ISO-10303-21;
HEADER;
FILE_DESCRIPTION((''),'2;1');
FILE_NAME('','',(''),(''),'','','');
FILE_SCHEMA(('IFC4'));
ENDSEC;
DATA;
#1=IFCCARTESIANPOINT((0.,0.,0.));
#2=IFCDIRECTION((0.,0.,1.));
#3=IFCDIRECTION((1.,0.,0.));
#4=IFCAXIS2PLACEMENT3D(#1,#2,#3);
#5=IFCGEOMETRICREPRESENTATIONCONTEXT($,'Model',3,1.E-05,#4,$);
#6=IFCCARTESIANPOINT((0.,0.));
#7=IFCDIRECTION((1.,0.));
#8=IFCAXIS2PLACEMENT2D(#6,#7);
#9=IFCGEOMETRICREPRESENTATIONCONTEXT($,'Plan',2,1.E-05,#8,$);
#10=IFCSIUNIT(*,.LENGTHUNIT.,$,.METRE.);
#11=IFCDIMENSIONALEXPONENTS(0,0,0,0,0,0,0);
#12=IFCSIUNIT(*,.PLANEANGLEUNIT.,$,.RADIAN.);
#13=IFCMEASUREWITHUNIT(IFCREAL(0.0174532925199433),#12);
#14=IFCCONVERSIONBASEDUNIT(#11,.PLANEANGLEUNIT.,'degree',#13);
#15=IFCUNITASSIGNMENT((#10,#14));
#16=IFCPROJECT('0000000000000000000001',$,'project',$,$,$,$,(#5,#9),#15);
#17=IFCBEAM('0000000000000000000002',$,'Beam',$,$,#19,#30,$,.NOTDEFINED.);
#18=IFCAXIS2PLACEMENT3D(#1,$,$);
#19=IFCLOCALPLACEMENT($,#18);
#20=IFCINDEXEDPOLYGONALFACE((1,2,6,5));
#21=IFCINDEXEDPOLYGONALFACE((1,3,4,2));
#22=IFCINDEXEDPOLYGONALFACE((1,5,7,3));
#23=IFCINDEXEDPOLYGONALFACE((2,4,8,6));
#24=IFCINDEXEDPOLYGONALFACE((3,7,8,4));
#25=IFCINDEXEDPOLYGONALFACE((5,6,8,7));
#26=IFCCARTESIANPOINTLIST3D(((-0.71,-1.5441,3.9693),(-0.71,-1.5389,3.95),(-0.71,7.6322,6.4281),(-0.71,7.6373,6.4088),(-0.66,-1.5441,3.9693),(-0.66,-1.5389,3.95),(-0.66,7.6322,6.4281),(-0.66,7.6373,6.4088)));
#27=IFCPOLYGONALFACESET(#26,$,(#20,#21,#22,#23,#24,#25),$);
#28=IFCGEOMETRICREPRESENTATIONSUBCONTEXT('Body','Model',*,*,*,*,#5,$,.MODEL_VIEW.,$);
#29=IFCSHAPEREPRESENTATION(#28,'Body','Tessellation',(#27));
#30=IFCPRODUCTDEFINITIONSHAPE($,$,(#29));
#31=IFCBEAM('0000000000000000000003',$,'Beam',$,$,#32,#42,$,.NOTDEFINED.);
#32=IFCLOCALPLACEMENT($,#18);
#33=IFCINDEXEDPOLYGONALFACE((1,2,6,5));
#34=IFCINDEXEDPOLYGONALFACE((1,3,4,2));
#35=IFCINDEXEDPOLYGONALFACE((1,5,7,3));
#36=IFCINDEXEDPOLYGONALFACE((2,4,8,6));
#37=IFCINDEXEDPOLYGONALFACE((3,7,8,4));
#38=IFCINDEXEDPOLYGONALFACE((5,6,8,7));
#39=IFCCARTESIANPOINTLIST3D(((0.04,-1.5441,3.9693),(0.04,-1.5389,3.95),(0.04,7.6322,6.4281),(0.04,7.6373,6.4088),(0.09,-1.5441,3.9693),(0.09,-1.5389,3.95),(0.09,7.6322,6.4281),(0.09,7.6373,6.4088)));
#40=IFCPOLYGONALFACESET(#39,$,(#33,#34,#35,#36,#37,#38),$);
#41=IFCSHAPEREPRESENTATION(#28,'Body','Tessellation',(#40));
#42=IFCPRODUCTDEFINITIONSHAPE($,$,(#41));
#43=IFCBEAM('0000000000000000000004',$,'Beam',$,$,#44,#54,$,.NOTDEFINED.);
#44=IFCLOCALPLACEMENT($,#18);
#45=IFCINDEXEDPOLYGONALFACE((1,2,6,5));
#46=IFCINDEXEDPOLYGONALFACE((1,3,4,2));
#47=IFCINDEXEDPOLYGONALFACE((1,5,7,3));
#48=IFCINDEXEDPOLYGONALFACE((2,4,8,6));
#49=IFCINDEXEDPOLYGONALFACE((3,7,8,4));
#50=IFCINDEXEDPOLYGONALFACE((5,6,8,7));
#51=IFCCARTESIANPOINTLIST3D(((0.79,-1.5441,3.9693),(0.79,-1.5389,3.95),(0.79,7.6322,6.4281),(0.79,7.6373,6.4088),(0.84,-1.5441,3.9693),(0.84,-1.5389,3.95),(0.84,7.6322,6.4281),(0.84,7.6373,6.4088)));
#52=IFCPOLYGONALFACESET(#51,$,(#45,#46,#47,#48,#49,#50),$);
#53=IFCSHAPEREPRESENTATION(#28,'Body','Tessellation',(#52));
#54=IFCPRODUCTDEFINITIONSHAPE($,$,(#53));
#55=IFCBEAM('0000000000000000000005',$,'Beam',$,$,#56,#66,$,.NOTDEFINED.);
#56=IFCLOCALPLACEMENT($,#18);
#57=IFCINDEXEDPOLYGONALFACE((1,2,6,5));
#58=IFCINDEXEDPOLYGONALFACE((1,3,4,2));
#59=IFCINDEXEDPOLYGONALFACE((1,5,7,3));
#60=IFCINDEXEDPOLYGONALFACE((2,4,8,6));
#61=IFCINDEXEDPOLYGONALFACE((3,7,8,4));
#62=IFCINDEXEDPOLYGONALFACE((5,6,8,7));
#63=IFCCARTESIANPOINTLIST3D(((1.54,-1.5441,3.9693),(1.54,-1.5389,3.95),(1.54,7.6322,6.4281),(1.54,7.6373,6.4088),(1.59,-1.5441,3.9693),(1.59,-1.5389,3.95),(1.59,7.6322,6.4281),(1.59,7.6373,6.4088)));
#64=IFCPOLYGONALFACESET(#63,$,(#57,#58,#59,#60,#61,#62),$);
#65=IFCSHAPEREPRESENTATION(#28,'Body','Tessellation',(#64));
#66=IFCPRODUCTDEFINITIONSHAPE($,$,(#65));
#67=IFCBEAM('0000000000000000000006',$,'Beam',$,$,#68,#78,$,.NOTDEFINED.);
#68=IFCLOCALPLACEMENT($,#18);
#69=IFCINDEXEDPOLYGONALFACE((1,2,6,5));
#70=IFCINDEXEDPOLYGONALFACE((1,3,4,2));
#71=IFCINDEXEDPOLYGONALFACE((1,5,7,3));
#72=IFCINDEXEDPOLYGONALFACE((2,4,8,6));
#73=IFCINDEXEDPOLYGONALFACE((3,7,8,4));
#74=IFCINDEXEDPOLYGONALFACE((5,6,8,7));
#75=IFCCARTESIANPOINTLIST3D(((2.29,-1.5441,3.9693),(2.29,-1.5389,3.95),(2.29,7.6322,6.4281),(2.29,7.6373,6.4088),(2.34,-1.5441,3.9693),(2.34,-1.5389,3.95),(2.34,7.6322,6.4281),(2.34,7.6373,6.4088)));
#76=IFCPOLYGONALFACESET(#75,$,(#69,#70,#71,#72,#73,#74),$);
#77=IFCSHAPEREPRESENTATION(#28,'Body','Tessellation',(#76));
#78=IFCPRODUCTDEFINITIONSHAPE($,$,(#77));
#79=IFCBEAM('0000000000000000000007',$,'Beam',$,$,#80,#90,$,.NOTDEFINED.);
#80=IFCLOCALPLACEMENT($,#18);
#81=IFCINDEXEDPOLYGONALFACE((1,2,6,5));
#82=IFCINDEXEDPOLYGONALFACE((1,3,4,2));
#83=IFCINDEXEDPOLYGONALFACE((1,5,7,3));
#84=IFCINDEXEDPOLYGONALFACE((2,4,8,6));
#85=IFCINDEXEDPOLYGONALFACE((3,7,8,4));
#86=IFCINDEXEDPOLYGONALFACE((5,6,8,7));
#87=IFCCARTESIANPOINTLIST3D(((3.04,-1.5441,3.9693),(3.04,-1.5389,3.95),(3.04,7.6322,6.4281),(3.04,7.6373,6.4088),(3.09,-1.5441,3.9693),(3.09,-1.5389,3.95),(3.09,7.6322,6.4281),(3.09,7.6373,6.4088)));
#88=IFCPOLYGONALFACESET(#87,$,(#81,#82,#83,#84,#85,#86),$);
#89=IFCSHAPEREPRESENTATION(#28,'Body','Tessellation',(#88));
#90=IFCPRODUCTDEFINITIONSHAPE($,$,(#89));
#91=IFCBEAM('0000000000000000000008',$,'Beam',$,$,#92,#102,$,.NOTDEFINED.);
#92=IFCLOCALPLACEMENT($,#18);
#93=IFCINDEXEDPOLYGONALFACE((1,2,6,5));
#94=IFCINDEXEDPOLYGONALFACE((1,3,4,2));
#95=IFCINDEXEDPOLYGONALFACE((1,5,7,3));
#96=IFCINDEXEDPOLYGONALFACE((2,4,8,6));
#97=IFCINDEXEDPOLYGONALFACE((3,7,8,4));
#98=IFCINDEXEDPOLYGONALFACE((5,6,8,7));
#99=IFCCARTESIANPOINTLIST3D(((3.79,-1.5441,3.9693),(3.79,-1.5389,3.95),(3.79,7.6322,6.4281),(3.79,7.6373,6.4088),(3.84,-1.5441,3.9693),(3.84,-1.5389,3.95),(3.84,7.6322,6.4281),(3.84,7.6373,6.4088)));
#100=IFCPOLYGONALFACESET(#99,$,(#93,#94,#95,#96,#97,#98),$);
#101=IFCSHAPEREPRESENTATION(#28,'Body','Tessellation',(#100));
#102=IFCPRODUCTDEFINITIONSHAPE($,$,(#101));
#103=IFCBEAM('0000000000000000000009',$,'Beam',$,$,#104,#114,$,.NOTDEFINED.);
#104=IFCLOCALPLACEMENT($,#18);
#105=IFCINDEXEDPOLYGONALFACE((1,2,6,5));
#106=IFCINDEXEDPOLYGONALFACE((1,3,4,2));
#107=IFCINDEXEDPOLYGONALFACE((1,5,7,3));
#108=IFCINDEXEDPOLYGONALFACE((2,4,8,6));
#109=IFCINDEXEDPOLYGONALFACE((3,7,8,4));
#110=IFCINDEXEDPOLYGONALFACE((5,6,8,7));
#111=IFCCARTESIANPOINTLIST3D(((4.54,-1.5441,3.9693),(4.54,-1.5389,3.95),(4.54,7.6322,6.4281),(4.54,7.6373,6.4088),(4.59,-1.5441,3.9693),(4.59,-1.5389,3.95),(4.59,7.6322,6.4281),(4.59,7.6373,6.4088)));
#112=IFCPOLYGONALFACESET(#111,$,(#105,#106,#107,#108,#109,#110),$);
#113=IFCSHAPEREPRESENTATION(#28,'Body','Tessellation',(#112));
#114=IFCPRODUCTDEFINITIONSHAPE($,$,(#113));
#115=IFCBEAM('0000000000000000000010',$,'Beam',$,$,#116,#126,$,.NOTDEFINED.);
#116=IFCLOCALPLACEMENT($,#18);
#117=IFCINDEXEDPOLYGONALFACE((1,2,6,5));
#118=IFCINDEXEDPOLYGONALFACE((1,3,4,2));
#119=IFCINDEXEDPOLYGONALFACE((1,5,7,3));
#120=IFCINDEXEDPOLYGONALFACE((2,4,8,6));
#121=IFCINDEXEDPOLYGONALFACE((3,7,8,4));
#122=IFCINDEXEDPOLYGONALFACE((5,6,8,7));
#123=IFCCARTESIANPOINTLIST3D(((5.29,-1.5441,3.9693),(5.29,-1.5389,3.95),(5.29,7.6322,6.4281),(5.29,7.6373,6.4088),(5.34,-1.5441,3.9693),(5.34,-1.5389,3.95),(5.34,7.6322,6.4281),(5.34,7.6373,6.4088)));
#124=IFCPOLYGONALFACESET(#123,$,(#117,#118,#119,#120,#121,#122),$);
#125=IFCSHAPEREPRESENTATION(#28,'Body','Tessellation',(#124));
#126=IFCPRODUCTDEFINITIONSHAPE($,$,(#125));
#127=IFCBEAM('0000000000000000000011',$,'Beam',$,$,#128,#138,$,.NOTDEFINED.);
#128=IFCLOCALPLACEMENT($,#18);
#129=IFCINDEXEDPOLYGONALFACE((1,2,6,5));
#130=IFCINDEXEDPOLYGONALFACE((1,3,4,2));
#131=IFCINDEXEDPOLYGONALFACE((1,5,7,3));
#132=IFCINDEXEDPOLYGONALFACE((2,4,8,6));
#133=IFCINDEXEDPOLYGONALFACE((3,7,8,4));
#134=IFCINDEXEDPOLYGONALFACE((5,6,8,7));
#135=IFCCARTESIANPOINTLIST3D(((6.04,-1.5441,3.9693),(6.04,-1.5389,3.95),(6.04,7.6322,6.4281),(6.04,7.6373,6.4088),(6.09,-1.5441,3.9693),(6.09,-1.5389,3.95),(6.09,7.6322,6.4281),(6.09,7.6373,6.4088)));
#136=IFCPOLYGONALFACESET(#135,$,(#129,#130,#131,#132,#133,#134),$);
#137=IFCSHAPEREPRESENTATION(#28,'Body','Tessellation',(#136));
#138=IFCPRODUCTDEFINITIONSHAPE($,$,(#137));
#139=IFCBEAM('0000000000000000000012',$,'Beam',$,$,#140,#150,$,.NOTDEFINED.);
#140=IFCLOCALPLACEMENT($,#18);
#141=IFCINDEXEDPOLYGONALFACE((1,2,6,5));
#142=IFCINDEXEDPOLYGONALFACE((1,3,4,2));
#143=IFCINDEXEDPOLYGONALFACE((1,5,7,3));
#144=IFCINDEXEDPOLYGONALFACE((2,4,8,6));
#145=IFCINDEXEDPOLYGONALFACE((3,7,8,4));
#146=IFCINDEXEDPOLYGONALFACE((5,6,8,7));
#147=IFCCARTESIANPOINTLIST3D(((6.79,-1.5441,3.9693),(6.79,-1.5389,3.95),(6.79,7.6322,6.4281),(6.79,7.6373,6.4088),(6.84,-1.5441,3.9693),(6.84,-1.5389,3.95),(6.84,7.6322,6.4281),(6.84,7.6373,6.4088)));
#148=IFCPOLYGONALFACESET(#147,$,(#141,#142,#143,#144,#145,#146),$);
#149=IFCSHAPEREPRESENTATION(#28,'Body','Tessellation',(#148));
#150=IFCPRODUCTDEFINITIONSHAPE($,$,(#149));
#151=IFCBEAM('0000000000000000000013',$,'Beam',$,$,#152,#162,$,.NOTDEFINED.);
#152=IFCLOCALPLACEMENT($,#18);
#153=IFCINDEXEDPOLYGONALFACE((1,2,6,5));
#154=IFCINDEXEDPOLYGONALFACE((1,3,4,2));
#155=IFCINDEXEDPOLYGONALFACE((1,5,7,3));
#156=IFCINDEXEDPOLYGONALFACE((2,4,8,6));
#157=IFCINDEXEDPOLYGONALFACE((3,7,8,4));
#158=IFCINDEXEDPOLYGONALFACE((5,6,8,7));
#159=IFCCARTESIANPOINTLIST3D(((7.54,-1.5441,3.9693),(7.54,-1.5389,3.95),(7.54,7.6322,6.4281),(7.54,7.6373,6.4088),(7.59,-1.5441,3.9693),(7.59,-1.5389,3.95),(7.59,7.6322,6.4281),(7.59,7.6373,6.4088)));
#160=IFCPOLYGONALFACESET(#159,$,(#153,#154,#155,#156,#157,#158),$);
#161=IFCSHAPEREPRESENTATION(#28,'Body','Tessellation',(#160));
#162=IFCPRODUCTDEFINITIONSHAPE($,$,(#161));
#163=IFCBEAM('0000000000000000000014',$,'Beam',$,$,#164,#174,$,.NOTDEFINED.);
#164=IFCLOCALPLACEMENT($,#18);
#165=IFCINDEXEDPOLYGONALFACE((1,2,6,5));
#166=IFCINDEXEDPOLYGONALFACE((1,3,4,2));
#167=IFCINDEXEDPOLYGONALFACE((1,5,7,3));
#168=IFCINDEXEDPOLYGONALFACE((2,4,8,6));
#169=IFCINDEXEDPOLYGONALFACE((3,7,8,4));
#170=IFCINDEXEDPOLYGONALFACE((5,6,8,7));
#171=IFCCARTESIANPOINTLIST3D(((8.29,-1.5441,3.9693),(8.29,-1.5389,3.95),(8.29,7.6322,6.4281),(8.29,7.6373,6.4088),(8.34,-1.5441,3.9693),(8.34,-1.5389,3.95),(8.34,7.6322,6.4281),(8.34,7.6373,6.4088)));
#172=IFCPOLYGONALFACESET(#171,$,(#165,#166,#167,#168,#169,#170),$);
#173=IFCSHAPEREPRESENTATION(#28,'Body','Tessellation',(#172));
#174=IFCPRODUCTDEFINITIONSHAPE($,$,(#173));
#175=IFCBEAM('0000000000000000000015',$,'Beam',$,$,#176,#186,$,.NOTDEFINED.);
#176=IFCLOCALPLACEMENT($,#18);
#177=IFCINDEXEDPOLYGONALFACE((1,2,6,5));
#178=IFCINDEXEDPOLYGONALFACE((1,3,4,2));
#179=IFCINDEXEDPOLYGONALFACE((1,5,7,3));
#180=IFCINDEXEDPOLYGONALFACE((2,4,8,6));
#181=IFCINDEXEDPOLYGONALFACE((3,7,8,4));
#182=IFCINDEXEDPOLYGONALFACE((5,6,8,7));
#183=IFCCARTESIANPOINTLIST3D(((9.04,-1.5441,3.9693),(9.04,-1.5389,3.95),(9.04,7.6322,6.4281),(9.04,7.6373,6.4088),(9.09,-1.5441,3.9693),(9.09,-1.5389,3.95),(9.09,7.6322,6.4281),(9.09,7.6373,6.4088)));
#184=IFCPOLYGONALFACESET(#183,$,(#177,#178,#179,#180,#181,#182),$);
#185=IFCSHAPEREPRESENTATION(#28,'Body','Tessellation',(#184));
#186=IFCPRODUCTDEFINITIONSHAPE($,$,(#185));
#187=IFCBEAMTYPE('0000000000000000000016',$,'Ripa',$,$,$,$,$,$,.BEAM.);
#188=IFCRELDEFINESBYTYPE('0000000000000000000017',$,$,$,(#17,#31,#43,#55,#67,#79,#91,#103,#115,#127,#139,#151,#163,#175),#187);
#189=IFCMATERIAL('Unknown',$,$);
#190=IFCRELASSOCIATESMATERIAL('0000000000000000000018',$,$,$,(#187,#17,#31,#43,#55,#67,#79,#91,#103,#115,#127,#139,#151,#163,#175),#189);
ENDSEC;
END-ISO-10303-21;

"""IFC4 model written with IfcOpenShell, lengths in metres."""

from ifc_helpers import new_model, entity, si_unit, converted_unit, frame, origin_with_axes, origin_2d_with_axis, place, context, subcontext, project, rectangle, extrude, material, material_profile, profile_set, profile_usage, type_object, element, save


model = new_model("IFC4")

# Units and contexts
model_context = context("Model", 3, precision=1e-05, world=origin_with_axes())
plan_context = context("Plan", 2, precision=1e-05, world=origin_2d_with_axis())
body_context = subcontext(model_context, "Body", "Model", "MODEL_VIEW")
ifc_project = project(units=[si_unit("LENGTHUNIT", "METRE"), converted_unit("PLANEANGLEUNIT", "degree", entity("IfcReal", 0.0174532925199433), si_unit("PLANEANGLEUNIT", "RADIAN"), dimensions=[0, 0, 0, 0, 0, 0, 0])], contexts=[model_context, plan_context])

# Beams
ifc_material = material(Name="Unknown")
ifc_material_profile = material_profile(ifc_material, rectangle(XDim=0.05, YDim=0.02))
ifc_profile_set = profile_set([ifc_material_profile])
ifc_profile_usage_1 = profile_usage(ifc_profile_set, cardinal=2)
beam_type = type_object("IfcBeamType", Name="Ripa", PredefinedType="BEAM", material=ifc_profile_set)
beam_1_placement = place(None, frame((-0.685, -1.5389, 3.95), z_axis=(-0.000001, 0.965926, 0.25882), x_axis=(-1.0, -0.000001, 0.0)))
element("IfcBeam", 1, at=beam_1_placement, type_object=beam_type, material=ifc_profile_usage_1, Name="Beam", PredefinedType="NOTDEFINED", context=body_context, shape_type="SweptSolid", body=[
    extrude(rectangle(XDim=0.05, YDim=0.02), frame((0.0, 0.01, 0.0), z_axis=(0.0, 0.0, 1.0), x_axis=(1.0, 0.0, 0.0)), (0.0, 0.0, 1.0), 9.4999),
])
ifc_profile_usage_2 = profile_usage(ifc_profile_set, cardinal=2)
beam_2_placement = place(None, frame((0.065, -1.5389, 3.95), z_axis=(-0.000001, 0.965926, 0.25882), x_axis=(-1.0, -0.000001, 0.0)))
element("IfcBeam", 2, at=beam_2_placement, type_object=beam_type, material=ifc_profile_usage_2, Name="Beam", PredefinedType="NOTDEFINED", context=body_context, shape_type="SweptSolid", body=[
    extrude(rectangle(XDim=0.05, YDim=0.02), frame((0.0, 0.01, 0.0), z_axis=(0.0, 0.0, 1.0), x_axis=(1.0, 0.0, 0.0)), (0.0, 0.0, 1.0), 9.4999),
])
ifc_profile_usage_3 = profile_usage(ifc_profile_set, cardinal=2)
beam_3_placement = place(None, frame((0.815, -1.5389, 3.95), z_axis=(-0.000001, 0.965926, 0.25882), x_axis=(-1.0, -0.000001, 0.0)))
element("IfcBeam", 3, at=beam_3_placement, type_object=beam_type, material=ifc_profile_usage_3, Name="Beam", PredefinedType="NOTDEFINED", context=body_context, shape_type="SweptSolid", body=[
    extrude(rectangle(XDim=0.05, YDim=0.02), frame((0.0, 0.01, 0.0), z_axis=(0.0, 0.0, 1.0), x_axis=(1.0, 0.0, 0.0)), (0.0, 0.0, 1.0), 9.4999),
])
ifc_profile_usage_4 = profile_usage(ifc_profile_set, cardinal=2)
beam_4_placement = place(None, frame((1.565, -1.5389, 3.95), z_axis=(-0.000001, 0.965926, 0.25882), x_axis=(-1.0, -0.000001, 0.0)))
element("IfcBeam", 4, at=beam_4_placement, type_object=beam_type, material=ifc_profile_usage_4, Name="Beam", PredefinedType="NOTDEFINED", context=body_context, shape_type="SweptSolid", body=[
    extrude(rectangle(XDim=0.05, YDim=0.02), frame((0.0, 0.01, 0.0), z_axis=(0.0, 0.0, 1.0), x_axis=(1.0, 0.0, 0.0)), (0.0, 0.0, 1.0), 9.4999),
])
ifc_profile_usage_5 = profile_usage(ifc_profile_set, cardinal=2)
beam_5_placement = place(None, frame((2.315, -1.5389, 3.95), z_axis=(-0.000001, 0.965926, 0.25882), x_axis=(-1.0, -0.000001, 0.0)))
element("IfcBeam", 5, at=beam_5_placement, type_object=beam_type, material=ifc_profile_usage_5, Name="Beam", PredefinedType="NOTDEFINED", context=body_context, shape_type="SweptSolid", body=[
    extrude(rectangle(XDim=0.05, YDim=0.02), frame((0.0, 0.01, 0.0), z_axis=(0.0, 0.0, 1.0), x_axis=(1.0, 0.0, 0.0)), (0.0, 0.0, 1.0), 9.4999),
])
ifc_profile_usage_6 = profile_usage(ifc_profile_set, cardinal=2)
beam_6_placement = place(None, frame((3.065, -1.5389, 3.95), z_axis=(-0.000001, 0.965926, 0.25882), x_axis=(-1.0, -0.000001, 0.0)))
element("IfcBeam", 6, at=beam_6_placement, type_object=beam_type, material=ifc_profile_usage_6, Name="Beam", PredefinedType="NOTDEFINED", context=body_context, shape_type="SweptSolid", body=[
    extrude(rectangle(XDim=0.05, YDim=0.02), frame((0.0, 0.01, 0.0), z_axis=(0.0, 0.0, 1.0), x_axis=(1.0, 0.0, 0.0)), (0.0, 0.0, 1.0), 9.4999),
])
ifc_profile_usage_7 = profile_usage(ifc_profile_set, cardinal=2)
beam_7_placement = place(None, frame((3.815, -1.5389, 3.95), z_axis=(-0.000001, 0.965926, 0.25882), x_axis=(-1.0, -0.000001, 0.0)))
element("IfcBeam", 7, at=beam_7_placement, type_object=beam_type, material=ifc_profile_usage_7, Name="Beam", PredefinedType="NOTDEFINED", context=body_context, shape_type="SweptSolid", body=[
    extrude(rectangle(XDim=0.05, YDim=0.02), frame((0.0, 0.01, 0.0), z_axis=(0.0, 0.0, 1.0), x_axis=(1.0, 0.0, 0.0)), (0.0, 0.0, 1.0), 9.4999),
])
ifc_profile_usage_8 = profile_usage(ifc_profile_set, cardinal=2)
beam_8_placement = place(None, frame((4.565, -1.5389, 3.95), z_axis=(-0.000001, 0.965926, 0.25882), x_axis=(-1.0, -0.000001, 0.0)))
element("IfcBeam", 8, at=beam_8_placement, type_object=beam_type, material=ifc_profile_usage_8, Name="Beam", PredefinedType="NOTDEFINED", context=body_context, shape_type="SweptSolid", body=[
    extrude(rectangle(XDim=0.05, YDim=0.02), frame((0.0, 0.01, 0.0), z_axis=(0.0, 0.0, 1.0), x_axis=(1.0, 0.0, 0.0)), (0.0, 0.0, 1.0), 9.4999),
])
ifc_profile_usage_9 = profile_usage(ifc_profile_set, cardinal=2)
beam_9_placement = place(None, frame((5.315, -1.5389, 3.95), z_axis=(-0.000001, 0.965926, 0.25882), x_axis=(-1.0, -0.000001, 0.0)))
element("IfcBeam", 9, at=beam_9_placement, type_object=beam_type, material=ifc_profile_usage_9, Name="Beam", PredefinedType="NOTDEFINED", context=body_context, shape_type="SweptSolid", body=[
    extrude(rectangle(XDim=0.05, YDim=0.02), frame((0.0, 0.01, 0.0), z_axis=(0.0, 0.0, 1.0), x_axis=(1.0, 0.0, 0.0)), (0.0, 0.0, 1.0), 9.4999),
])
ifc_profile_usage_10 = profile_usage(ifc_profile_set, cardinal=2)
beam_10_placement = place(None, frame((6.065, -1.5389, 3.95), z_axis=(-0.000001, 0.965926, 0.25882), x_axis=(-1.0, -0.000001, 0.0)))
element("IfcBeam", 10, at=beam_10_placement, type_object=beam_type, material=ifc_profile_usage_10, Name="Beam", PredefinedType="NOTDEFINED", context=body_context, shape_type="SweptSolid", body=[
    extrude(rectangle(XDim=0.05, YDim=0.02), frame((0.0, 0.01, 0.0), z_axis=(0.0, 0.0, 1.0), x_axis=(1.0, 0.0, 0.0)), (0.0, 0.0, 1.0), 9.4999),
])
ifc_profile_usage_11 = profile_usage(ifc_profile_set, cardinal=2)
beam_11_placement = place(None, frame((6.815, -1.5389, 3.95), z_axis=(-0.000001, 0.965926, 0.25882), x_axis=(-1.0, -0.000001, 0.0)))
element("IfcBeam", 11, at=beam_11_placement, type_object=beam_type, material=ifc_profile_usage_11, Name="Beam", PredefinedType="NOTDEFINED", context=body_context, shape_type="SweptSolid", body=[
    extrude(rectangle(XDim=0.05, YDim=0.02), frame((0.0, 0.01, 0.0), z_axis=(0.0, 0.0, 1.0), x_axis=(1.0, 0.0, 0.0)), (0.0, 0.0, 1.0), 9.4999),
])
ifc_profile_usage_12 = profile_usage(ifc_profile_set, cardinal=2)
beam_12_placement = place(None, frame((7.565, -1.5389, 3.95), z_axis=(-0.000001, 0.965926, 0.25882), x_axis=(-1.0, -0.000001, 0.0)))
element("IfcBeam", 12, at=beam_12_placement, type_object=beam_type, material=ifc_profile_usage_12, Name="Beam", PredefinedType="NOTDEFINED", context=body_context, shape_type="SweptSolid", body=[
    extrude(rectangle(XDim=0.05, YDim=0.02), frame((0.0, 0.01, 0.0), z_axis=(0.0, 0.0, 1.0), x_axis=(1.0, 0.0, 0.0)), (0.0, 0.0, 1.0), 9.4999),
])
ifc_profile_usage_13 = profile_usage(ifc_profile_set, cardinal=2)
beam_13_placement = place(None, frame((8.315, -1.5389, 3.95), z_axis=(-0.000001, 0.965926, 0.25882), x_axis=(-1.0, -0.000001, 0.0)))
element("IfcBeam", 13, at=beam_13_placement, type_object=beam_type, material=ifc_profile_usage_13, Name="Beam", PredefinedType="NOTDEFINED", context=body_context, shape_type="SweptSolid", body=[
    extrude(rectangle(XDim=0.05, YDim=0.02), frame((0.0, 0.01, 0.0), z_axis=(0.0, 0.0, 1.0), x_axis=(1.0, 0.0, 0.0)), (0.0, 0.0, 1.0), 9.4999),
])
ifc_profile_usage_14 = profile_usage(ifc_profile_set, cardinal=2)
beam_14_placement = place(None, frame((9.065, -1.5389, 3.95), z_axis=(-0.000001, 0.965926, 0.25882), x_axis=(-1.0, -0.000001, 0.0)))
element("IfcBeam", 14, at=beam_14_placement, type_object=beam_type, material=ifc_profile_usage_14, Name="Beam", PredefinedType="NOTDEFINED", context=body_context, shape_type="SweptSolid", body=[
    extrude(rectangle(XDim=0.05, YDim=0.02), frame((0.0, 0.01, 0.0), z_axis=(0.0, 0.0, 1.0), x_axis=(1.0, 0.0, 0.0)), (0.0, 0.0, 1.0), 9.4999),
])

save(model, "model.ifc")
